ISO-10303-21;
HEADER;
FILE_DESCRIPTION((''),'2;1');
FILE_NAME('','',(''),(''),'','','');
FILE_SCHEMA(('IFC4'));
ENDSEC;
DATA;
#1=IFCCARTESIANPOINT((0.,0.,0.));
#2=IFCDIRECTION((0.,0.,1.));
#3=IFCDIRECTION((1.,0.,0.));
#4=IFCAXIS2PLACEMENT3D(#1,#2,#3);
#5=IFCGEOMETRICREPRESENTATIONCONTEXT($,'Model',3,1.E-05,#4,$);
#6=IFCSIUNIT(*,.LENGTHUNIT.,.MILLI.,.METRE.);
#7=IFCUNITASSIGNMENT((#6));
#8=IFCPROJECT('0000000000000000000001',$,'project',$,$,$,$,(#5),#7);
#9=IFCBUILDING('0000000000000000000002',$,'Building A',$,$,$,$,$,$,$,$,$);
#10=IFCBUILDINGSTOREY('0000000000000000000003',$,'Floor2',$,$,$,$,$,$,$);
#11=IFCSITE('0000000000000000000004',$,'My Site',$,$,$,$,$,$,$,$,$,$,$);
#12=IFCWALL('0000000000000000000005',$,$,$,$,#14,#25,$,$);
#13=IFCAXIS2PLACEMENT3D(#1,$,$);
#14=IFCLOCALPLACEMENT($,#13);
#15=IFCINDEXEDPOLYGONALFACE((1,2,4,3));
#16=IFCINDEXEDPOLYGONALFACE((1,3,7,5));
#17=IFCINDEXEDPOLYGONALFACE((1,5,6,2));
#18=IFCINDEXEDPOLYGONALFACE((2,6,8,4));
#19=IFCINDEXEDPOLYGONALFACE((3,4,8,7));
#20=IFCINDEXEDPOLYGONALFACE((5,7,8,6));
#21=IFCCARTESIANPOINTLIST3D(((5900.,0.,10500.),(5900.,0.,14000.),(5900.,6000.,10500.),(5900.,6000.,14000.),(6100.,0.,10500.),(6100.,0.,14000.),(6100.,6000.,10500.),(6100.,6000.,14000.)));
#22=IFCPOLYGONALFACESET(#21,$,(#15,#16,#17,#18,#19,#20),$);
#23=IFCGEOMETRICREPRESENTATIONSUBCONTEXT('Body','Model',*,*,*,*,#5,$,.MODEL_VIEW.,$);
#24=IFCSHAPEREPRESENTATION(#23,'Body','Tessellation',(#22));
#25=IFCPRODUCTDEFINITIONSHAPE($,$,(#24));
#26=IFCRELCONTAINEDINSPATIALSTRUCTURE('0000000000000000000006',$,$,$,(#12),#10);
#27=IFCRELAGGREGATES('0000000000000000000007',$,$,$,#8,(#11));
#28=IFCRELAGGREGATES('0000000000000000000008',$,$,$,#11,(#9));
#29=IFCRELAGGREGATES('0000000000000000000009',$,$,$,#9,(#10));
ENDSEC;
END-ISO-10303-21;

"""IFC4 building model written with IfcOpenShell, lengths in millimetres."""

from ifc_helpers import new_model, si_unit, frame, origin_with_axes, place, context, subcontext, project, spatial, indexed_curve, outline, extrude, element, save


model = new_model("IFC4")

# Units and contexts
model_context = context("Model", 3, precision=1e-05, world=origin_with_axes())
body_context = subcontext(model_context, "Body", "Model", "MODEL_VIEW")
ifc_project = project(units=[si_unit("LENGTHUNIT", "METRE", prefix="MILLI")], contexts=[model_context])

# Site, building, storey
site = spatial("IfcSite", under=ifc_project, Name="My Site")
building = spatial("IfcBuilding", under=site, Name="Building A")
storey = spatial("IfcBuildingStorey", under=building, Name="Floor2")

# Wall
wall_placement = place(None, frame((6100.0, 0.0, 10500.0), z_axis=(0.0, 0.0, 1.0), x_axis=(0.0, 1.0, 0.0)))
element("IfcWall", 1, at=wall_placement, inside=storey, context=body_context, shape_type="SweptSolid", body=[
    extrude(outline(indexed_curve([(0.0, 0.0), (0.0, 200.0), (6000.0, 200.0), (6000.0, 0.0), (0.0, 0.0)], self_intersect=False)), origin_with_axes(), (0.0, 0.0, 1.0), 3500.0),
])

save(model, "model.ifc")
